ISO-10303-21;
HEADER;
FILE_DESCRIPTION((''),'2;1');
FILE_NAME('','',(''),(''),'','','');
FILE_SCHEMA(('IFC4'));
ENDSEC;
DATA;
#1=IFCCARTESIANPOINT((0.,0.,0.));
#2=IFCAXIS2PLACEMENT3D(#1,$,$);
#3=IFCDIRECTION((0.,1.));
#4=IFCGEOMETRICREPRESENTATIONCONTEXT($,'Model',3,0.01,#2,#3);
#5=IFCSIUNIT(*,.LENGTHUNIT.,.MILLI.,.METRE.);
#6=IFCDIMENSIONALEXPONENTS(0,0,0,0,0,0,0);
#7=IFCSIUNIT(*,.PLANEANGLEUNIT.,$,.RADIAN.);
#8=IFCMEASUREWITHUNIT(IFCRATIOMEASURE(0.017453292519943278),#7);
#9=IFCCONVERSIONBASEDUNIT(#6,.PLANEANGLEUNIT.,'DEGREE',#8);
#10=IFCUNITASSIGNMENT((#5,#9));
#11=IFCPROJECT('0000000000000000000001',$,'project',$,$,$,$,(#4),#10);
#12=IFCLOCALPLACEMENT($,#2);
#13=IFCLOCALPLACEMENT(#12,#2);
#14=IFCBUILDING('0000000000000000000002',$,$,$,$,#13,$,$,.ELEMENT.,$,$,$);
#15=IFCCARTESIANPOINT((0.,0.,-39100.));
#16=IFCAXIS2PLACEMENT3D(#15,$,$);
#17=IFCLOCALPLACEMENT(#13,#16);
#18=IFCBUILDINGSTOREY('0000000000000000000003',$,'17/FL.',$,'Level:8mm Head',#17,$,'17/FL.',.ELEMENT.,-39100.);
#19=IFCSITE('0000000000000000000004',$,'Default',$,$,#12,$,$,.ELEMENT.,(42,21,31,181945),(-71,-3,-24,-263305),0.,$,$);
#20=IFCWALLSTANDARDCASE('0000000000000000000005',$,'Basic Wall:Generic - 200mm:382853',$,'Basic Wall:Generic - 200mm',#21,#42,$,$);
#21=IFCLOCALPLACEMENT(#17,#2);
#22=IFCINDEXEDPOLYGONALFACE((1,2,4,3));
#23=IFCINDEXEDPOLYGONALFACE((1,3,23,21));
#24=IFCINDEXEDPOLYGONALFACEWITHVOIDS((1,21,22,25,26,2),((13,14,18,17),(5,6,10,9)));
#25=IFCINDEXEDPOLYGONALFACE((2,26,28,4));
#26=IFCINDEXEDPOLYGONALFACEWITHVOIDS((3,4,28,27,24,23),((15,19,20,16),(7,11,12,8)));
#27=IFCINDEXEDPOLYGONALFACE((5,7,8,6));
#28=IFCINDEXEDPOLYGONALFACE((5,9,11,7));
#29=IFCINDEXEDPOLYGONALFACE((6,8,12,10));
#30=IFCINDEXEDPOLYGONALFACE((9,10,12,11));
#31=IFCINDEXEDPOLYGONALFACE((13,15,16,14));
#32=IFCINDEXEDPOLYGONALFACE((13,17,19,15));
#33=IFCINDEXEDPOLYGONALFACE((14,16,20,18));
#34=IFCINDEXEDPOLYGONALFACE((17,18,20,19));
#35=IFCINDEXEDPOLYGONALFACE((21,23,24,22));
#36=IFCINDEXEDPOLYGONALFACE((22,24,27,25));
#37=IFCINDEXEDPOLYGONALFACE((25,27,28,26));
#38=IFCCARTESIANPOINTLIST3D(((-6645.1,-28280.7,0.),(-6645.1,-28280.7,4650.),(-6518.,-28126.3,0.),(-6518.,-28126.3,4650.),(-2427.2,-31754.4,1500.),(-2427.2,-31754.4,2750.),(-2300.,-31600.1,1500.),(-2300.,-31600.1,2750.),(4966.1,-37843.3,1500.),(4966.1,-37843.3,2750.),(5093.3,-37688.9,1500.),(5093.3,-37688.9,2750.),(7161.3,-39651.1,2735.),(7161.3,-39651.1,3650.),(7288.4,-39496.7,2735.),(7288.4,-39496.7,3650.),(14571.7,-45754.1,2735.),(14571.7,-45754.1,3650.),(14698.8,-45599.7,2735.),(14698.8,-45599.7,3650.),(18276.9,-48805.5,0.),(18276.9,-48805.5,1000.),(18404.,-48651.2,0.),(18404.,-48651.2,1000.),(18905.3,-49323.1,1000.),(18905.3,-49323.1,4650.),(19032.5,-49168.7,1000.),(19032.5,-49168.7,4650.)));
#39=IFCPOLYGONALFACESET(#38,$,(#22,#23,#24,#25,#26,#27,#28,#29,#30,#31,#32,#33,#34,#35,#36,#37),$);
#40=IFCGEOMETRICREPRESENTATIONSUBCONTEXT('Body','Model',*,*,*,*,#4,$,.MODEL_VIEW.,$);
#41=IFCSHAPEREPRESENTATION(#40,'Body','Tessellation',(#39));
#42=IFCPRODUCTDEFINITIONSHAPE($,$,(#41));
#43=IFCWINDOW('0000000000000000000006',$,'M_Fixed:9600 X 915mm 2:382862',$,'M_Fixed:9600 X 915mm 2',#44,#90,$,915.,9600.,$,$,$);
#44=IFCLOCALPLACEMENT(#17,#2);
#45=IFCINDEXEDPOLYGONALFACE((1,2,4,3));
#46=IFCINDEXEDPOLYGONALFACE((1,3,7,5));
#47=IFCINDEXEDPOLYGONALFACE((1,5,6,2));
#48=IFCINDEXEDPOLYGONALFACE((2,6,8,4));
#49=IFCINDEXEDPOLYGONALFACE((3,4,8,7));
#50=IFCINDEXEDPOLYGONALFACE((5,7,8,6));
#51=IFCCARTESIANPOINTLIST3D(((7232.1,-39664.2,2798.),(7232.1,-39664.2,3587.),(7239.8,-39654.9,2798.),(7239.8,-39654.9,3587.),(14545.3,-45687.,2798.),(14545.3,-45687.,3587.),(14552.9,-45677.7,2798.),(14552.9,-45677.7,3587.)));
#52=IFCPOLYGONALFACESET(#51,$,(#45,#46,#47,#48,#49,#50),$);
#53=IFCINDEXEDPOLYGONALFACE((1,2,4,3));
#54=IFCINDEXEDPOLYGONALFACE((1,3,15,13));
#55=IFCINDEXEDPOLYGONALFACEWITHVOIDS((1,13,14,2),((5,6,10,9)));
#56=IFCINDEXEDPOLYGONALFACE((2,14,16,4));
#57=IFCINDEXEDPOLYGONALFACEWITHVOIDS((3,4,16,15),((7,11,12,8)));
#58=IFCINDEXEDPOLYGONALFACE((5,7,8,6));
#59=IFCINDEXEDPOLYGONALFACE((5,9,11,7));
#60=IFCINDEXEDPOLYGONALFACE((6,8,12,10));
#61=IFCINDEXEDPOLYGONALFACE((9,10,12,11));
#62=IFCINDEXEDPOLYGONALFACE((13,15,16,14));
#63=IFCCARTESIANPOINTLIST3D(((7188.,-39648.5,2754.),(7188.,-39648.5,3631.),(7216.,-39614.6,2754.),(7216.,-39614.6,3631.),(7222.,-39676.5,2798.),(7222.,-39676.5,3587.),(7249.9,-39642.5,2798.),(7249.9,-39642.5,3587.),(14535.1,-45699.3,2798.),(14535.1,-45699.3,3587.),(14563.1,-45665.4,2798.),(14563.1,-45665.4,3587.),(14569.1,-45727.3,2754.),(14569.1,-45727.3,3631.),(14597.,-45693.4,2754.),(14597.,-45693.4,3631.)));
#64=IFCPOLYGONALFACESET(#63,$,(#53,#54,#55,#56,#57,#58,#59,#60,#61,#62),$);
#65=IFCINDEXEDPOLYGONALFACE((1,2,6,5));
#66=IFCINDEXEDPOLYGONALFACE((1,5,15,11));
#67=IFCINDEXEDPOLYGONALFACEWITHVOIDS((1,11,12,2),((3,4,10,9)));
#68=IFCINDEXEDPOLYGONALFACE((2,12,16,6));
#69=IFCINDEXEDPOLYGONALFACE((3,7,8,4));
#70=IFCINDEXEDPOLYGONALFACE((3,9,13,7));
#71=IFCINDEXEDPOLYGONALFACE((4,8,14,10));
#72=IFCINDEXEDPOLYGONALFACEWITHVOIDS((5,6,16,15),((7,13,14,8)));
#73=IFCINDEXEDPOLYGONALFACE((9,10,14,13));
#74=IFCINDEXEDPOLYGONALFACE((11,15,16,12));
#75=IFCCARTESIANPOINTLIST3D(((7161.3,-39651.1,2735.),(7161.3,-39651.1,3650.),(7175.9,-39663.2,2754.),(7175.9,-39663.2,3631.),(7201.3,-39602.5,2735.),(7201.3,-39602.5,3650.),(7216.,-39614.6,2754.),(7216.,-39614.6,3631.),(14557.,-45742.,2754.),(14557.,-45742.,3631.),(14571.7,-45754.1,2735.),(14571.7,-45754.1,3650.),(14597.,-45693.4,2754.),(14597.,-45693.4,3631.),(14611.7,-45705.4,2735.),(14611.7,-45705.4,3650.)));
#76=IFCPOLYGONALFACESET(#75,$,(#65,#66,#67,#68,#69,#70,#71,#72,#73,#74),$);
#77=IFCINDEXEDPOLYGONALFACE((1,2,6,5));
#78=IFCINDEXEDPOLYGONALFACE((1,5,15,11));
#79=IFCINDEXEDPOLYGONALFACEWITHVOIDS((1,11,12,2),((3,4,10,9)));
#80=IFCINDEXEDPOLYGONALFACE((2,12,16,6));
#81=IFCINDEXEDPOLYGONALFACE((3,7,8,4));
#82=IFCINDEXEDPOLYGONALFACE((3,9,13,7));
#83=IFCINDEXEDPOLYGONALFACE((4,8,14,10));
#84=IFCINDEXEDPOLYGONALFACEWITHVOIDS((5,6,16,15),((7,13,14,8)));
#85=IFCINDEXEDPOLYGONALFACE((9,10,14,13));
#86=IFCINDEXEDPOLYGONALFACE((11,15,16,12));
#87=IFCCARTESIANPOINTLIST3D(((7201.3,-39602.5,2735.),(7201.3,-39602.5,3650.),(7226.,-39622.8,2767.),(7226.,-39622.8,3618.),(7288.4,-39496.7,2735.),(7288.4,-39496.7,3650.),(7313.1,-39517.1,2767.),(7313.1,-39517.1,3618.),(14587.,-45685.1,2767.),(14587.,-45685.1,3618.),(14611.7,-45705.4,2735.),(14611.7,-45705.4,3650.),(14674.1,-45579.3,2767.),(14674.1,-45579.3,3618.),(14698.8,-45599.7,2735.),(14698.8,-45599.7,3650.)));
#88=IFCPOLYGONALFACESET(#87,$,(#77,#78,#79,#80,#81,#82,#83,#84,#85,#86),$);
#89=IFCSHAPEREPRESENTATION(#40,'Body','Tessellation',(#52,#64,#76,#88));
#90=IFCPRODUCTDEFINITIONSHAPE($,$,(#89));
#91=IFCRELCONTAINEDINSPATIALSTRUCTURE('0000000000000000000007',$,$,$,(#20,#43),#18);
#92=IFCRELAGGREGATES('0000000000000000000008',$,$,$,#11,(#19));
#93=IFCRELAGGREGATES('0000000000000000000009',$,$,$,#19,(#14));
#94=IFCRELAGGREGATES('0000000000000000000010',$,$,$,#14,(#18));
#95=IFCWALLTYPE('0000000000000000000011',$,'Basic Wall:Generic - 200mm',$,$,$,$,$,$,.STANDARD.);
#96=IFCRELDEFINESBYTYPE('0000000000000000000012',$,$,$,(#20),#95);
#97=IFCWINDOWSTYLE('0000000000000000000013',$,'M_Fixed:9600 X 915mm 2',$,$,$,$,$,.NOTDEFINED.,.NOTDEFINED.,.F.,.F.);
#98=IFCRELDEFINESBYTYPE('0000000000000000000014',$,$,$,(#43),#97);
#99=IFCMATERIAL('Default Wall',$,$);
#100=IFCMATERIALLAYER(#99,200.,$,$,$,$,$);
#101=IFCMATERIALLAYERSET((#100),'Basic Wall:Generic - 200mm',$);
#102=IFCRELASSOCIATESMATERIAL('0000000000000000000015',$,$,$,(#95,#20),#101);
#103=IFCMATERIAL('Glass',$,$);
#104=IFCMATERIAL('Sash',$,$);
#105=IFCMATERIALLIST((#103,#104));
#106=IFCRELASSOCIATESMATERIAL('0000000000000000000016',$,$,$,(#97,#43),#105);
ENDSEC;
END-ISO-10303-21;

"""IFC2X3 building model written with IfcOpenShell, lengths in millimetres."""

from ifc_helpers import new_model, entity, si_unit, converted_unit, direction, frame, frame_2d, origin, place, context, subcontext, project, spatial, polyline, rectangle, outline, extrude, source, transform, mapped, material, material_list, layer, layer_set, layer_usage, type_object, type_shapes, element, fill, save


model = new_model("IFC2X3")

# Units and contexts
model_context = context("Model", 3, precision=0.01, world=origin(), true_north=direction((0.0, 1.0)))
body_context = subcontext(model_context, "Body", "Model", "MODEL_VIEW")
ifc_project = project(units=[si_unit("LENGTHUNIT", "METRE", prefix="MILLI"), converted_unit("PLANEANGLEUNIT", "DEGREE", entity("IfcRatioMeasure", 0.017453292519943278), si_unit("PLANEANGLEUNIT", "RADIAN"), dimensions=[0, 0, 0, 0, 0, 0, 0])], contexts=[model_context])

# Site, building, storey
site_placement = place(None, origin())
site = spatial("IfcSite", under=ifc_project, at=site_placement, Name="Default", CompositionType="ELEMENT", RefLatitude=(42, 21, 31, 181945), RefLongitude=(-71, -3, -24, -263305), RefElevation=0.0)
building_placement = place(site_placement, origin())
building = spatial("IfcBuilding", under=site, at=building_placement, CompositionType="ELEMENT")
storey_placement = place(building_placement, frame((0.0, 0.0, -39100.0)))
storey = spatial("IfcBuildingStorey", under=building, at=storey_placement, Name="17/FL.", ObjectType="Level:8mm Head", LongName="17/FL.", CompositionType="ELEMENT", Elevation=-39100.0)

# Shared definitions
ifc_material_1 = material(Name="Default Wall")
ifc_layer = layer(ifc_material_1, 200.0)
ifc_layer_set = layer_set([ifc_layer], Name="Basic Wall:Generic - 200mm")
ifc_layer_usage = layer_usage(ifc_layer_set, "AXIS2", "NEGATIVE", 100.0)
wall_type = type_object("IfcWallType", Name="Basic Wall:Generic - 200mm", PredefinedType="STANDARD", material=ifc_layer_set)

# Shared definitions
ifc_material_2 = material(Name="Glass")
ifc_material_3 = material(Name="Sash")
ifc_material_list = material_list([ifc_material_2, ifc_material_3])

# Wall, openings, window
wall_1_placement = place(storey_placement, frame((-6581.6, -28203.5, 0.0), z_axis=(0.0, 0.0, 1.0), x_axis=(0.771917, -0.635723, 0.0)))
wall_1 = element("IfcWallStandardCase", 1, at=wall_1_placement, inside=storey, type_object=wall_type, material=ifc_layer_usage, Name="Basic Wall:Generic - 200mm:382853", ObjectType="Basic Wall:Generic - 200mm", context=body_context, shape_type="SweptSolid", body=[
    extrude(rectangle(XDim=33100.0, YDim=200.0, at=frame_2d((16550.0, 0.0), x_axis=(-1.0, 0.0))), origin(), (0.0, 0.0, 1.0), 4650.0),
])
opening_1_placement = place(wall_1_placement, origin())
element("IfcOpeningElement", 2, at=opening_1_placement, cuts=wall_1, ObjectType="Opening", context=body_context, shape_type="SweptSolid", body=[
    extrude(rectangle(XDim=1250.0, YDim=9577.8, at=frame_2d((0.0, 0.0), x_axis=(1.0, 0.0))), frame((10253.2, -100.0, 2125.0), z_axis=(0.0, 1.0, 0.0), x_axis=(0.0, 0.0, -1.0)), (0.0, 0.0, 1.0), 200.0),
])
opening_2_placement = place(wall_1_placement, frame((-12849.2, 25954.8, 0.0), z_axis=(0.0, 0.0, 1.0), x_axis=(0.771917, 0.635723, 0.0)))
element("IfcOpeningElement", 3, at=opening_2_placement, cuts=wall_1, ObjectType="Opening", context=body_context, shape_type="SweptSolid", body=[
    extrude(rectangle(XDim=1000.0, YDim=1010.1, at=frame_2d((0.0, 0.0), x_axis=(1.0, 0.0))), frame((18658.7, -49136.4, 500.0), z_axis=(0.635723, 0.771917, 0.0), x_axis=(0.0, 0.0, -1.0)), (0.0, 0.0, 1.0), 1012.7),
])
opening_3_placement = place(wall_1_placement, frame((27485.9, 100.0, 2735.0)))
opening_3 = element("IfcOpeningElement", 4, at=opening_3_placement, cuts=wall_1, ObjectType="Opening", context=body_context, shape_type="SweptSolid", body=[
    extrude(rectangle(XDim=915.0, YDim=9600.0, at=frame_2d((457.5, 4800.0), x_axis=(1.0, 0.0))), frame((0.0, 0.0, 0.0), z_axis=(0.0, -1.0, 0.0), x_axis=(0.0, 0.0, 1.0)), (0.0, 0.0, 1.0), 200.0),
])
window_style_1 = type_object("IfcWindowStyle", Name="M_Fixed:9600 X 915mm 2", ConstructionType="NOTDEFINED", OperationType="NOTDEFINED", ParameterTakesPrecedence=False, Sizeable=False, material=ifc_material_list)
shared_shape_1 = source(origin(), body_context, "Body", "SweptSolid", [
    extrude(rectangle(XDim=12.0, YDim=9474.0, at=frame_2d((0.0, 0.0), x_axis=(1.0, 0.0))), frame((4800.0, 159.0, 63.0), z_axis=(0.0, 0.0, 1.0), x_axis=(0.0, -1.0, 0.0)), (0.0, 0.0, 1.0), 789.0),
    extrude(outline(polyline([(-4781.0, -438.5), (4781.0, -438.5), (4781.0, 438.5), (-4781.0, 438.5), (-4781.0, -438.5)]), holes=[polyline([(-4737.0, -394.5), (-4737.0, 394.5), (4737.0, 394.5), (4737.0, -394.5), (-4737.0, -394.5)])]), frame((4800.0, 137.0, 457.5), z_axis=(0.0, 1.0, 0.0), x_axis=(1.0, 0.0, 0.0)), (0.0, 0.0, 1.0), 44.0),
    extrude(outline(polyline([(-4800.0, -457.5), (4800.0, -457.5), (4800.0, 457.5), (-4800.0, 457.5), (-4800.0, -457.5)]), holes=[polyline([(-4781.0, -438.5), (-4781.0, 438.5), (4781.0, 438.5), (4781.0, -438.5), (-4781.0, -438.5)])]), frame((4800.0, 137.0, 457.5), z_axis=(0.0, 1.0, 0.0), x_axis=(1.0, 0.0, 0.0)), (0.0, 0.0, 1.0), 63.0),
    extrude(outline(polyline([(-4800.0, -457.5), (4800.0, -457.5), (4800.0, 457.5), (-4800.0, 457.5), (-4800.0, -457.5)]), holes=[polyline([(-4768.0, -425.5), (-4768.0, 425.5), (4768.0, 425.5), (4768.0, -425.5), (-4768.0, -425.5)])]), frame((4800.0, 0.0, 457.5), z_axis=(0.0, 1.0, 0.0), x_axis=(1.0, 0.0, 0.0)), (0.0, 0.0, 1.0), 137.0),
])
type_shapes(window_style_1, [shared_shape_1])
window_1_placement = place(opening_3_placement, frame((0.0, 0.0, 0.0), z_axis=(0.0, 0.0, 1.0), x_axis=(-1.0, 0.0, 0.0)))
window_1 = element("IfcWindow", 5, at=window_1_placement, inside=storey, type_object=window_style_1, material=ifc_material_list, Name="M_Fixed:9600 X 915mm 2:382862", ObjectType="M_Fixed:9600 X 915mm 2", OverallHeight=915.0, OverallWidth=9600.0, context=body_context, shape_type="MappedRepresentation", body=[
    mapped(shared_shape_1, transform((0.0, 0.0, 0.0), scale=1.0)),
])
fill(opening_3, window_1)

save(model, "model.ifc")
